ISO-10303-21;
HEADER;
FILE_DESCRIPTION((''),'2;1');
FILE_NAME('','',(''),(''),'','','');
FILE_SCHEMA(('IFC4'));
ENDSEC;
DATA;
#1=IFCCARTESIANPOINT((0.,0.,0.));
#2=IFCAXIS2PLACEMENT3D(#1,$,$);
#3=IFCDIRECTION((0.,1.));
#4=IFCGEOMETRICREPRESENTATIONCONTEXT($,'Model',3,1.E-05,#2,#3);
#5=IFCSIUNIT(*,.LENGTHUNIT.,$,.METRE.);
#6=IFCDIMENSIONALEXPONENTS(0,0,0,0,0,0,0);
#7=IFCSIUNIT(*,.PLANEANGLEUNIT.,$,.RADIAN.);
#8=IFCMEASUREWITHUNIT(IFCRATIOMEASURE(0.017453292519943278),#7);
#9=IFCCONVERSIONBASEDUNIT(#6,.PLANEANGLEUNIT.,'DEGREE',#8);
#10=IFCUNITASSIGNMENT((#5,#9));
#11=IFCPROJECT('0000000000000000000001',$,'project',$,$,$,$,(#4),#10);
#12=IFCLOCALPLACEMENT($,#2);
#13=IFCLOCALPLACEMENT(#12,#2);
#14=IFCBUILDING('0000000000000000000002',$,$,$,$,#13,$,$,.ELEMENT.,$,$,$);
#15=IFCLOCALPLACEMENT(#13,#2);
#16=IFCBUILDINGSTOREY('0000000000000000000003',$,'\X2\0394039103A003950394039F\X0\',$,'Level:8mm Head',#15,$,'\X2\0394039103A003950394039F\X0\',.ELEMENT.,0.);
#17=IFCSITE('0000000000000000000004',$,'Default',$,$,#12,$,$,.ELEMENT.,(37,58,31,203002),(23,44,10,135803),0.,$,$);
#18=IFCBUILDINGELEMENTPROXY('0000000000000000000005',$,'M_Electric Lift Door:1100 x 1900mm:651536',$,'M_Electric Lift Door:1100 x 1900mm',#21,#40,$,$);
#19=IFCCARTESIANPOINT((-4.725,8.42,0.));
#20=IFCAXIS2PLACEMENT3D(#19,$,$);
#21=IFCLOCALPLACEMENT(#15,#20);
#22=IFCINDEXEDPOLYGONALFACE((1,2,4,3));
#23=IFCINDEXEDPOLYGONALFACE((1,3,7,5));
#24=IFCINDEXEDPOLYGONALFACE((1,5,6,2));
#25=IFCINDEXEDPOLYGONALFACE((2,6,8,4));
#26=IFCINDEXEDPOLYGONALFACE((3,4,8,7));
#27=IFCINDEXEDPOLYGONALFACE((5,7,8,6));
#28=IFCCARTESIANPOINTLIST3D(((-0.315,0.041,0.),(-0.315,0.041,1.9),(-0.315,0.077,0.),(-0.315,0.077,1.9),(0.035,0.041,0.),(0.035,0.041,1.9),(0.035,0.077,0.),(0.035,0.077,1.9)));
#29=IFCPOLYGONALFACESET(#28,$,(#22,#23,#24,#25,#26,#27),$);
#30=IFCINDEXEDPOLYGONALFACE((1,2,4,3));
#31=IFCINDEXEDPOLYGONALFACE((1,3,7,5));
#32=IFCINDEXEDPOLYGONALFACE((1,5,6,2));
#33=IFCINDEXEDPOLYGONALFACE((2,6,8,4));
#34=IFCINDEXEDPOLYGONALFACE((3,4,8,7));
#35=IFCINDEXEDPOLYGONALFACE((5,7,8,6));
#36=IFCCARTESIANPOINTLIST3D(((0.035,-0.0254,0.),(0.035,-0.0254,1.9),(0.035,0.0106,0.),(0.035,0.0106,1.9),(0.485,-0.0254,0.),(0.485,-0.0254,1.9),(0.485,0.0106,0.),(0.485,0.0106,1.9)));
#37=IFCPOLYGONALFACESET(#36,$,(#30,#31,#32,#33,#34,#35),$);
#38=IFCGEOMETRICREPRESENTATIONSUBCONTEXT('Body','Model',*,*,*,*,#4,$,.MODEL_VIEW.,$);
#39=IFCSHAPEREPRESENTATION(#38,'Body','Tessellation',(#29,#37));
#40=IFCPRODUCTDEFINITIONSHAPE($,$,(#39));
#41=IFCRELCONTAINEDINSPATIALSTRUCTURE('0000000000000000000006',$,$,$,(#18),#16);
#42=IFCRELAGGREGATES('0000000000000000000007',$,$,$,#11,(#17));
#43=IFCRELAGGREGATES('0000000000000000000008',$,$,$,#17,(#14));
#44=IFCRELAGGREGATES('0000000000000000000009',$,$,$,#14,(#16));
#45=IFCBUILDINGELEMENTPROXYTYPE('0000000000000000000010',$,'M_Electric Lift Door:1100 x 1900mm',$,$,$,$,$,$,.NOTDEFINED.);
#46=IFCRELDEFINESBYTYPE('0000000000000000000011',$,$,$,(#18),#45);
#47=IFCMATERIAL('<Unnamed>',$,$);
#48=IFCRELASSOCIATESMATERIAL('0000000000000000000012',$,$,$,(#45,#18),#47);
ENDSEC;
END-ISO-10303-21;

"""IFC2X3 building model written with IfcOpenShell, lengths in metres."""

from ifc_helpers import new_model, entity, si_unit, converted_unit, direction, frame, frame_2d, origin, origin_2d_with_axis, place, context, subcontext, project, spatial, rectangle, extrude, source, transform, mapped, material, type_object, type_shapes, element, save


model = new_model("IFC2X3")

# Units and contexts
model_context = context("Model", 3, precision=1e-05, world=origin(), true_north=direction((0.0, 1.0)))
body_context = subcontext(model_context, "Body", "Model", "MODEL_VIEW")
ifc_project = project(units=[si_unit("LENGTHUNIT", "METRE"), converted_unit("PLANEANGLEUNIT", "DEGREE", entity("IfcRatioMeasure", 0.017453292519943278), si_unit("PLANEANGLEUNIT", "RADIAN"), dimensions=[0, 0, 0, 0, 0, 0, 0])], contexts=[model_context])

# Site, building, storey
site_placement = place(None, origin())
site = spatial("IfcSite", under=ifc_project, at=site_placement, Name="Default", CompositionType="ELEMENT", RefLatitude=(37, 58, 31, 203002), RefLongitude=(23, 44, 10, 135803), RefElevation=0.0)
building_placement = place(site_placement, origin())
building = spatial("IfcBuilding", under=site, at=building_placement, CompositionType="ELEMENT")
storey_placement = place(building_placement, origin())
storey = spatial("IfcBuildingStorey", under=building, at=storey_placement, Name="ΔΑΠΕΔΟ", ObjectType="Level:8mm Head", LongName="ΔΑΠΕΔΟ", CompositionType="ELEMENT", Elevation=0.0)

# Building element proxy
ifc_material_1 = material(Name="<Unnamed>")
building_element_proxy_type_1 = type_object("IfcBuildingElementProxyType", Name="M_Electric Lift Door:1100 x 1900mm", PredefinedType="NOTDEFINED", material=ifc_material_1)
shared_shape_1 = source(origin(), body_context, "Body", "SweptSolid", [
    extrude(rectangle(XDim=0.036, YDim=0.35, at=frame_2d((0.0, 0.0), x_axis=(1.0, 0.0))), frame((-0.14, 0.059, 0.0), z_axis=(0.0, 0.0, 1.0), x_axis=(0.0, -1.0, 0.0)), (0.0, 0.0, 1.0), 1.9),
    extrude(rectangle(XDim=0.036, YDim=0.45, at=origin_2d_with_axis()), frame((0.26, -0.0074, 0.0), z_axis=(0.0, 0.0, 1.0), x_axis=(0.0, -1.0, 0.0)), (0.0, 0.0, 1.0), 1.9),
])
type_shapes(building_element_proxy_type_1, [shared_shape_1])
proxy_1_placement = place(storey_placement, frame((-4.725, 8.42, 0.0)))
element("IfcBuildingElementProxy", 1, at=proxy_1_placement, inside=storey, type_object=building_element_proxy_type_1, material=ifc_material_1, Name="M_Electric Lift Door:1100 x 1900mm:651536", ObjectType="M_Electric Lift Door:1100 x 1900mm", context=body_context, shape_type="MappedRepresentation", body=[
    mapped(shared_shape_1, transform((0.0, 0.0, 0.0), scale=1.0)),
])

save(model, "model.ifc")
